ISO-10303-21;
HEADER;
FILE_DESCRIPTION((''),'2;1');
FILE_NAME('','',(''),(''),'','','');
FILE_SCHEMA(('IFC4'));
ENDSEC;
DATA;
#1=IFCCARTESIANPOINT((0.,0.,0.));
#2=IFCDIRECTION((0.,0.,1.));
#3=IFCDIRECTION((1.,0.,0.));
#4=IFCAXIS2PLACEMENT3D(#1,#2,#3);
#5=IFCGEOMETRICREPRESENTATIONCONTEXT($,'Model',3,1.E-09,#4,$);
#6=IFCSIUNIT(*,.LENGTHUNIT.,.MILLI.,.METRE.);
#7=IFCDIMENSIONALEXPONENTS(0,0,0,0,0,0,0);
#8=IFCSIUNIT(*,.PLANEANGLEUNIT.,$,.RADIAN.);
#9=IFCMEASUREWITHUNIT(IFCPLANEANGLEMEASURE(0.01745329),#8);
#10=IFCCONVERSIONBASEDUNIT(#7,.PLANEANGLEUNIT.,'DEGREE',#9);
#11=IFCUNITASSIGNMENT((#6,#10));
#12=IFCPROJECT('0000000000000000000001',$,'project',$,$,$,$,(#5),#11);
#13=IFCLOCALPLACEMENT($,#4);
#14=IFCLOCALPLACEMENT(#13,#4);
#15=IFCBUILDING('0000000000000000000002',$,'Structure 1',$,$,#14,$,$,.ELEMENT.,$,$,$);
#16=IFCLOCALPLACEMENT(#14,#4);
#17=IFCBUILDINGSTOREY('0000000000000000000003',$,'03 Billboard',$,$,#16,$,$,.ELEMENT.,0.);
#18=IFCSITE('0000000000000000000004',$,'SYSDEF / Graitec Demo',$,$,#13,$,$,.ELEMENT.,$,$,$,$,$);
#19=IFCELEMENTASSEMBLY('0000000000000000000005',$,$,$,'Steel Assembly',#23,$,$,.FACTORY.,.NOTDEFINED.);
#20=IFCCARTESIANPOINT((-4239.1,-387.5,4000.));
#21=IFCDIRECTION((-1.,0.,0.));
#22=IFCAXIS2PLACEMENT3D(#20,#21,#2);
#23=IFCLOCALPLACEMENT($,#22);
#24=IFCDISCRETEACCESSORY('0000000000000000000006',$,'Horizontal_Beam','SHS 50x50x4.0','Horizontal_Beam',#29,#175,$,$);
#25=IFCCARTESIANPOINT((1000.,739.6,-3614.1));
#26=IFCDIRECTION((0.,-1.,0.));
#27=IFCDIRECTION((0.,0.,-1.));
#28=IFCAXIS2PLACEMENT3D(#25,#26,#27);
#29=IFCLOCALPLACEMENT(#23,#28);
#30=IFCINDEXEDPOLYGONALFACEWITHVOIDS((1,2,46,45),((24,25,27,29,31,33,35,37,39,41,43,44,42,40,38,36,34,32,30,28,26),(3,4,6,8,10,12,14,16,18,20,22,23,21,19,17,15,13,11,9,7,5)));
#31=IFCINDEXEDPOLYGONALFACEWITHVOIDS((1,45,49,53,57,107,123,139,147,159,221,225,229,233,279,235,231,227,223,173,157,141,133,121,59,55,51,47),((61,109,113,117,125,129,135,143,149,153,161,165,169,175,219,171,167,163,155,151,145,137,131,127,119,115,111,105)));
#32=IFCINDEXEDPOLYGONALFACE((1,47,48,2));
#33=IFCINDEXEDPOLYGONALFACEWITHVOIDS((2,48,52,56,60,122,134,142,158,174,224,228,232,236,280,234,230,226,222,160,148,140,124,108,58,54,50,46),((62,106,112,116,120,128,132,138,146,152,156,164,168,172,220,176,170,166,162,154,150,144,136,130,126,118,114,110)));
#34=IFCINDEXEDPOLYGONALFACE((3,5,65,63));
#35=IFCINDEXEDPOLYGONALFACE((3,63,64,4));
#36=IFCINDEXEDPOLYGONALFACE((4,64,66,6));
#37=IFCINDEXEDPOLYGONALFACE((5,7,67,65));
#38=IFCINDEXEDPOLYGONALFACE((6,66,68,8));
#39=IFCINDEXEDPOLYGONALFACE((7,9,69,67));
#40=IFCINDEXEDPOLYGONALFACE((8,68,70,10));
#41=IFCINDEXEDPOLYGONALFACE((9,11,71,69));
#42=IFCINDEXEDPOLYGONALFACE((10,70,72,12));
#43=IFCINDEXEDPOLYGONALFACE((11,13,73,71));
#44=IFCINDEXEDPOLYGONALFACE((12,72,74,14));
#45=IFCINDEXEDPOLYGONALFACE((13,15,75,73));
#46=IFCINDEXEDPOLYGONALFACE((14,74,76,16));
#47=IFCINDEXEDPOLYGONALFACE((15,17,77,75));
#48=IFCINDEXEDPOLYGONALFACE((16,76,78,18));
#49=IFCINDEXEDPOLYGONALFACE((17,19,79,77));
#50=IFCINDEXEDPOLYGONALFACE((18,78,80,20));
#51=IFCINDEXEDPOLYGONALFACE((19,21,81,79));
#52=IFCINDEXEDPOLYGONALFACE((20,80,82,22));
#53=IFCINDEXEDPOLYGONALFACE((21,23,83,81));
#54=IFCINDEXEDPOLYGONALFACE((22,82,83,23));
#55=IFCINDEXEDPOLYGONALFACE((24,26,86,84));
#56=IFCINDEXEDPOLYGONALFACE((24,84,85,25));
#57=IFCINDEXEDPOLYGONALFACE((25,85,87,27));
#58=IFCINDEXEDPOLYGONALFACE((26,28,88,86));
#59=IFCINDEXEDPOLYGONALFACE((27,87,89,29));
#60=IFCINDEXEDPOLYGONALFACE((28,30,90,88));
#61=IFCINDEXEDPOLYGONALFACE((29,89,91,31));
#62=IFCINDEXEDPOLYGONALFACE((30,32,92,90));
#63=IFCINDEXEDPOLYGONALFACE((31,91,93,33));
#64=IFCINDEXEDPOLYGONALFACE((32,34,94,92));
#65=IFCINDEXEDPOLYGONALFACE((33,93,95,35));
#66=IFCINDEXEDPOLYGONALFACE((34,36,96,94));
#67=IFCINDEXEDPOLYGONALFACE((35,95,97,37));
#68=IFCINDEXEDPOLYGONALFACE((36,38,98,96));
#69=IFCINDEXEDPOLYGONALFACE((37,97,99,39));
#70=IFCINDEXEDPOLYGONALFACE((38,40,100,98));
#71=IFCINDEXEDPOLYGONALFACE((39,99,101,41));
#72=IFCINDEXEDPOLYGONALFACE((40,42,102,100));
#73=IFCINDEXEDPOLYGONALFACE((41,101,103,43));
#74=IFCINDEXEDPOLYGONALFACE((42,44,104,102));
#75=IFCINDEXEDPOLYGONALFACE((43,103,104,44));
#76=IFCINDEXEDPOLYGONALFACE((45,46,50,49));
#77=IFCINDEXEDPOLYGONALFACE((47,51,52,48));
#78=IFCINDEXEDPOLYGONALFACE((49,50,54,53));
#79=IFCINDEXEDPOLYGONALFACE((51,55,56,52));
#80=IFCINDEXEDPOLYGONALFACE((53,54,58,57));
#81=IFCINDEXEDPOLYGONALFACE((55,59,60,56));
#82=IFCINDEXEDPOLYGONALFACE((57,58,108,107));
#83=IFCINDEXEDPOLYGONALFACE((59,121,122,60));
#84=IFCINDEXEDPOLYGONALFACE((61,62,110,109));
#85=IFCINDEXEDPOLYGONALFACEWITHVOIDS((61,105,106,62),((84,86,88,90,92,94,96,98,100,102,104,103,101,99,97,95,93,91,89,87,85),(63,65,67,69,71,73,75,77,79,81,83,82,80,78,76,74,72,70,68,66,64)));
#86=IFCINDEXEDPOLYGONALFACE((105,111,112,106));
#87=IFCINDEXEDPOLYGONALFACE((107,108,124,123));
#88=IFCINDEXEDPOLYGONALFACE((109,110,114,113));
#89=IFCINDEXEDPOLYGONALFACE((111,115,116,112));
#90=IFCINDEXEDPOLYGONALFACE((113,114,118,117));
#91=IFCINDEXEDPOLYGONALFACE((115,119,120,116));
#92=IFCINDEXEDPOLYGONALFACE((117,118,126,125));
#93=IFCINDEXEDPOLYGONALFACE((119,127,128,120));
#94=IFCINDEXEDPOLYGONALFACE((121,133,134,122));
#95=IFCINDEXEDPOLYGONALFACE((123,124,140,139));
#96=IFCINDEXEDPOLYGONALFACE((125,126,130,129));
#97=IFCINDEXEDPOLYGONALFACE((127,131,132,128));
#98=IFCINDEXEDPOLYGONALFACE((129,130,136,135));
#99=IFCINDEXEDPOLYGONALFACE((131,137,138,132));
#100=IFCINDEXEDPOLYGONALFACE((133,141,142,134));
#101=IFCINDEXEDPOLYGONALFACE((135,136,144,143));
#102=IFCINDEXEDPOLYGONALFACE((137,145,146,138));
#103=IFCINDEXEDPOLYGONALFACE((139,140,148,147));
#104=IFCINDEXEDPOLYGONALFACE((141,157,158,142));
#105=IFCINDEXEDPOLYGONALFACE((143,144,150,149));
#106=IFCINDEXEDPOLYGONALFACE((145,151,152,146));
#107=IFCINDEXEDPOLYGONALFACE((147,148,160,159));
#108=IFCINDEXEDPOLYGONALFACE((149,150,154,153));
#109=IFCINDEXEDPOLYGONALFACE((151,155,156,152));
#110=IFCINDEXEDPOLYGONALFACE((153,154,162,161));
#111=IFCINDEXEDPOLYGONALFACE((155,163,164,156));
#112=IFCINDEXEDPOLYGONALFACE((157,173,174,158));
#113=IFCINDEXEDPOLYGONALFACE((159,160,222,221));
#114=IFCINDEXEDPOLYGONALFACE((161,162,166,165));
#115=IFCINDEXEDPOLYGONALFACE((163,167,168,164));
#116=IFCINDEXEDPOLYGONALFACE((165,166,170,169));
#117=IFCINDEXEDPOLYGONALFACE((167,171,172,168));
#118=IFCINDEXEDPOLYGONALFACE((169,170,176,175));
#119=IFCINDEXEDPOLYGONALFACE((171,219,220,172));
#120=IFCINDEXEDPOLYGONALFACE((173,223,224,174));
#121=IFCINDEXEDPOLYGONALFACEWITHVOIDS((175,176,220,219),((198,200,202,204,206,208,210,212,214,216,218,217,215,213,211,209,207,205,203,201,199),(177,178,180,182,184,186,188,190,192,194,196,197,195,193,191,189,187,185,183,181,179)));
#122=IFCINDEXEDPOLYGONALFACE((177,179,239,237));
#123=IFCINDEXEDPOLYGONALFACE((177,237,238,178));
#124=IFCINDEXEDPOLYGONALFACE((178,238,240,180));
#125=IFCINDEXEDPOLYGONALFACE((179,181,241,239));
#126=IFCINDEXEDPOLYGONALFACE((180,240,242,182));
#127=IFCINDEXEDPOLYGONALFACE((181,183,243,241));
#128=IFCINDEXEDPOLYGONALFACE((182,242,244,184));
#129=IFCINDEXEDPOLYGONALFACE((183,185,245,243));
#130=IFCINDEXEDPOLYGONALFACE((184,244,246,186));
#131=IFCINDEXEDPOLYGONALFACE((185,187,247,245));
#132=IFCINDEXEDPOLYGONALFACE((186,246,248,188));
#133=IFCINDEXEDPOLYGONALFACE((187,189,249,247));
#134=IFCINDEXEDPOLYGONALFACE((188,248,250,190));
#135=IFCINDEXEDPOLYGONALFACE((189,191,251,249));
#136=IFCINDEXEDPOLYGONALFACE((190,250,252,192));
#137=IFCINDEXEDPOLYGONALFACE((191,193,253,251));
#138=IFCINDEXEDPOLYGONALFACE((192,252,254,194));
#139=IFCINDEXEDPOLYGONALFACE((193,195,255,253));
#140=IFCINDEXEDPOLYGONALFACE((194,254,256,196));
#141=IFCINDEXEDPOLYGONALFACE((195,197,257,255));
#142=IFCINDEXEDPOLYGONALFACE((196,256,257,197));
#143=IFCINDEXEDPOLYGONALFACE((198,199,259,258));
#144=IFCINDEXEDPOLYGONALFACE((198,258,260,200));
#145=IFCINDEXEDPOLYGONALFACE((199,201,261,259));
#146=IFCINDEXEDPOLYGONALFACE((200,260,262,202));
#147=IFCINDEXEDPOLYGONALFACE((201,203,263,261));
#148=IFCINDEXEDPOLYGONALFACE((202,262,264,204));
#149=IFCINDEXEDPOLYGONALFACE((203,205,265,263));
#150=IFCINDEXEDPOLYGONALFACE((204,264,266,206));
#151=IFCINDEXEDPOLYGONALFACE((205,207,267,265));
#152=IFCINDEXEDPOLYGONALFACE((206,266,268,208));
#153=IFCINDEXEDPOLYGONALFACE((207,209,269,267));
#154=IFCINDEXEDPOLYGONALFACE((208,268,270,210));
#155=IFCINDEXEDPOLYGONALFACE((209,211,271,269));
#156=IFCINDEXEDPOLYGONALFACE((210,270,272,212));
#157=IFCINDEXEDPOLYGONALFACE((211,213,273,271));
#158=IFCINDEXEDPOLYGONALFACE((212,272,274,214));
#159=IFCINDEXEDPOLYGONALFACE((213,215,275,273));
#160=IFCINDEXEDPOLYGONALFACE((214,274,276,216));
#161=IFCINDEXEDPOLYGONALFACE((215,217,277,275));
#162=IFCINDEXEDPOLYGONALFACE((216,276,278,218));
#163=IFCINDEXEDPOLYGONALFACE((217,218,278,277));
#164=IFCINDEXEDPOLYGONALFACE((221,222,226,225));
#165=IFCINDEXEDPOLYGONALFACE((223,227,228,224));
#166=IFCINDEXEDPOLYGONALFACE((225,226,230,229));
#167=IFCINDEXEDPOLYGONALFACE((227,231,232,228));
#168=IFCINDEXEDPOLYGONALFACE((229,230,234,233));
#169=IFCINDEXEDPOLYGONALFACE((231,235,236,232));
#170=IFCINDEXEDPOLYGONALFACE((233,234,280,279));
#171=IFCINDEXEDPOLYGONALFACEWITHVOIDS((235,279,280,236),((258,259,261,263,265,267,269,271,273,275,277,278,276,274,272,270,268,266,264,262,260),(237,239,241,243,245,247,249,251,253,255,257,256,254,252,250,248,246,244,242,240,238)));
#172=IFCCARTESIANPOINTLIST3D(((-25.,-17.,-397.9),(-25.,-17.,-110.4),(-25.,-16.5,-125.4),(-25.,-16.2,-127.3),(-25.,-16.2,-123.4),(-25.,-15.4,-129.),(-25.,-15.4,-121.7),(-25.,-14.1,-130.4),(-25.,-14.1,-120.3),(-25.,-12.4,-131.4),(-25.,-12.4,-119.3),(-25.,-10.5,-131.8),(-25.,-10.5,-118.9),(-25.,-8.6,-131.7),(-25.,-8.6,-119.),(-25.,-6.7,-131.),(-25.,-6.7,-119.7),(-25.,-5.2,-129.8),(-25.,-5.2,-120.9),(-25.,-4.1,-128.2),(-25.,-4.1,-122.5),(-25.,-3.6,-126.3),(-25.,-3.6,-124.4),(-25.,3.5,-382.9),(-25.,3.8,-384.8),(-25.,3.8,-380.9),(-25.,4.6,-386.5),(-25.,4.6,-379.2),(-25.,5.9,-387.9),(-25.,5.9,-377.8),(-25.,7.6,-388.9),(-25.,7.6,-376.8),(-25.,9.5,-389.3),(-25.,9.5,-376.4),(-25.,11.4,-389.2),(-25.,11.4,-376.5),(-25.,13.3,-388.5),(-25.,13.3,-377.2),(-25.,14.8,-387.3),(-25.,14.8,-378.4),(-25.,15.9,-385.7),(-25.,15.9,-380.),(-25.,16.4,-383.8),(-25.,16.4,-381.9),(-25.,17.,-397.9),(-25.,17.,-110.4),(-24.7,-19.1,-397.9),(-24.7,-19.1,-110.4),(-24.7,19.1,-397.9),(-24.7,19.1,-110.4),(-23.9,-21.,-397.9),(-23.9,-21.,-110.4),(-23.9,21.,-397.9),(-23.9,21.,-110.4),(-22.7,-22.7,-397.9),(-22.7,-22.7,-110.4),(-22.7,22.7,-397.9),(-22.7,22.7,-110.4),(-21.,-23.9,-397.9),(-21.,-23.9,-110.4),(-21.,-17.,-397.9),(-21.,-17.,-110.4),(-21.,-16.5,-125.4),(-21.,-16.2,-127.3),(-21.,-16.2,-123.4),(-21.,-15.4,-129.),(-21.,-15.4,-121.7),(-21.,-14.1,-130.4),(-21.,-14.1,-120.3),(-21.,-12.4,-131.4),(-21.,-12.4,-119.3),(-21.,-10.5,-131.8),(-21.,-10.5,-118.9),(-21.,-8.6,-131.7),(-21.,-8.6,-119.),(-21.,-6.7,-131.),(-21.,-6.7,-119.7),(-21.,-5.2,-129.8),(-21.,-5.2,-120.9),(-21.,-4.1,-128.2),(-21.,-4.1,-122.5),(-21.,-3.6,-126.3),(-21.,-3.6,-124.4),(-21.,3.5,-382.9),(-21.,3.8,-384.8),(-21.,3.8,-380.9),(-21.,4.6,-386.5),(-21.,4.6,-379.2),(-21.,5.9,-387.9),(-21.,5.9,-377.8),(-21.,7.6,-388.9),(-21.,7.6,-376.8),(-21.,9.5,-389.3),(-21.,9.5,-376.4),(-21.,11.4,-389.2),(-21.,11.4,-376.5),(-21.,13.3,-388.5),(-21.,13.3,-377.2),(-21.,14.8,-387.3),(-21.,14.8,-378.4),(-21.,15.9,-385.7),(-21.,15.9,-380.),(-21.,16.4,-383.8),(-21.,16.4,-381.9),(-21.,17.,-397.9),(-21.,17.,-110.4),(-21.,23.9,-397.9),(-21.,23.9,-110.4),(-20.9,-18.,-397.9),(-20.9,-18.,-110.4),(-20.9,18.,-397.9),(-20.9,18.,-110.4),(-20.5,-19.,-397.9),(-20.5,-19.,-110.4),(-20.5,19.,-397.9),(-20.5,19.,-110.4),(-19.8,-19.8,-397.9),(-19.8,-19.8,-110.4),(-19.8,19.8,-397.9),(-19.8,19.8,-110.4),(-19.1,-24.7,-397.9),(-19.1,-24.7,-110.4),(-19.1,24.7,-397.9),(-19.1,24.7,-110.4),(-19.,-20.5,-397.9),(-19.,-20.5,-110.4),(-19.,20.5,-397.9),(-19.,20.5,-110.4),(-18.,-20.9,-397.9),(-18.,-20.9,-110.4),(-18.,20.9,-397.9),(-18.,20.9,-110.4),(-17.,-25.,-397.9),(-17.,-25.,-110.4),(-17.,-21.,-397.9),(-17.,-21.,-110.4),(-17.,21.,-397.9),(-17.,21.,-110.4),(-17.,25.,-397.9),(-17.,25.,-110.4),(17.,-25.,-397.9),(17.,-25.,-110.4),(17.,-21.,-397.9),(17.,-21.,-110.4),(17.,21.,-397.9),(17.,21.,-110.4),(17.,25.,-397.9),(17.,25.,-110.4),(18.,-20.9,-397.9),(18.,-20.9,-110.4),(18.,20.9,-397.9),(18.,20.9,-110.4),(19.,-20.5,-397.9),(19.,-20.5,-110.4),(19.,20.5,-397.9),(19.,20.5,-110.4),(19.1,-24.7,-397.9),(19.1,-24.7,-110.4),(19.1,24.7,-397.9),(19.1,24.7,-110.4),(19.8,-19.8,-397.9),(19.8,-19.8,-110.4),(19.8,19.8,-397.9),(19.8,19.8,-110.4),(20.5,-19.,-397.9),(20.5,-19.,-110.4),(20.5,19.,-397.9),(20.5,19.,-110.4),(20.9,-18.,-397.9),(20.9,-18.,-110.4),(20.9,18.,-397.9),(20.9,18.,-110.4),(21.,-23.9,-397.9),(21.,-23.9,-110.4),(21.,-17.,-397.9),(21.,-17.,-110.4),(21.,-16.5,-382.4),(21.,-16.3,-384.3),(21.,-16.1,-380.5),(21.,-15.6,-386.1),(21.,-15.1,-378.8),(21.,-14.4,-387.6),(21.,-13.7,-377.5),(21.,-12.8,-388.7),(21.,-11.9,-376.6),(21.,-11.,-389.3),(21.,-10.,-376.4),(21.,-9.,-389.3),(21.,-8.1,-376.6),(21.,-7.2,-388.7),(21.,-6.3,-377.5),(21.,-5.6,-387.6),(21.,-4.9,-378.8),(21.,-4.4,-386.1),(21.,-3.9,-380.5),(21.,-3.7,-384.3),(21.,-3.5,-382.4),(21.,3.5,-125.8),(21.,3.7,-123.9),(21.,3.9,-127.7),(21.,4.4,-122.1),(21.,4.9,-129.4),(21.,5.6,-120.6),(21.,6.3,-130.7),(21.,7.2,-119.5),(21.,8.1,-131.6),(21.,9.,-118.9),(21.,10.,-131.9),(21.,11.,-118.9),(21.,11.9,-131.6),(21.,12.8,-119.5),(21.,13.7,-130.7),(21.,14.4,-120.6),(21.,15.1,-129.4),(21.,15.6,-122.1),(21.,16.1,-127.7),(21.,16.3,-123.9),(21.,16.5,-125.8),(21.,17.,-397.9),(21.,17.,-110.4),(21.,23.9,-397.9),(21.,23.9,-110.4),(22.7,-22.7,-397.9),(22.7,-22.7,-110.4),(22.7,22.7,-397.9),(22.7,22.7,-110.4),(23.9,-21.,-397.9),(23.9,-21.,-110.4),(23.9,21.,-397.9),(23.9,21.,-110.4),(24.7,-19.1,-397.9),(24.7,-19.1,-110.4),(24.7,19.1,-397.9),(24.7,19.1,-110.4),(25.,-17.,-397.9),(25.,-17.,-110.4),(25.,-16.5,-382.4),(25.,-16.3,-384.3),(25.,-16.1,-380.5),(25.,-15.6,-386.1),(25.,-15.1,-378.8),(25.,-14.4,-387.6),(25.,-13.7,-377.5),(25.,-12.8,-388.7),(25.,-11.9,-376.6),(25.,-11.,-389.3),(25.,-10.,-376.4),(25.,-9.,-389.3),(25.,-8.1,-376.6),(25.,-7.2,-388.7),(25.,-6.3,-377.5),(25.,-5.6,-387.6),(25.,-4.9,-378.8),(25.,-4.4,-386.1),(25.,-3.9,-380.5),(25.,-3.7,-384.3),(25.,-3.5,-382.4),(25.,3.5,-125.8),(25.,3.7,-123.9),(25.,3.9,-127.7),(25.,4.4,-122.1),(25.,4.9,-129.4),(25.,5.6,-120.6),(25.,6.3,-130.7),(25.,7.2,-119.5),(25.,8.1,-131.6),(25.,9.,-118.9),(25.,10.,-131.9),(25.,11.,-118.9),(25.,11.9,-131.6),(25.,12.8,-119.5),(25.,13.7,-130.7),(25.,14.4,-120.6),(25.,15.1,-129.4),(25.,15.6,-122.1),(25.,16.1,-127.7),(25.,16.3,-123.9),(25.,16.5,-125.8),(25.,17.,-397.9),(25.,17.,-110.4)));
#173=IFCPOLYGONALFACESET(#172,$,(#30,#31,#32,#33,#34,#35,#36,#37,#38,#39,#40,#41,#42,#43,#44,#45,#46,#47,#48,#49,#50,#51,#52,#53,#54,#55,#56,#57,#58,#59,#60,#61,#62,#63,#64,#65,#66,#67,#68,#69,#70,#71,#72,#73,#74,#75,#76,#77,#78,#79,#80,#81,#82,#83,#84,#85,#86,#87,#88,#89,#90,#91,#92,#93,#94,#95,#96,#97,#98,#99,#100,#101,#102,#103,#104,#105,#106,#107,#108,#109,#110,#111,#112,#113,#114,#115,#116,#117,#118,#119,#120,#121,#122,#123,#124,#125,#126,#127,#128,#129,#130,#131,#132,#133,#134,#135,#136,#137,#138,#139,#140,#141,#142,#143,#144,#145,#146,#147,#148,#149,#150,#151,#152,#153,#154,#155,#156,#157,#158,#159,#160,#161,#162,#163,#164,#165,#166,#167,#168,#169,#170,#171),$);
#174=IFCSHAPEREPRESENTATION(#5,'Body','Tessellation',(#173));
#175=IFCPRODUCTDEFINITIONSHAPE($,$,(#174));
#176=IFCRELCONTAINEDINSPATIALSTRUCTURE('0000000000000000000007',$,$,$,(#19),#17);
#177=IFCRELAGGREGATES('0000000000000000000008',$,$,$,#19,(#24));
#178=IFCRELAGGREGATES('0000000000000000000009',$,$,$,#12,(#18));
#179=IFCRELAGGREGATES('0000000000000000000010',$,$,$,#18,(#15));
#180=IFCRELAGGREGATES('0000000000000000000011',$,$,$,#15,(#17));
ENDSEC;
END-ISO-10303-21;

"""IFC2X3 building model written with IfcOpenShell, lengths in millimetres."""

from ifc_helpers import new_model, entity, si_unit, converted_unit, frame, frame_2d, origin, origin_with_axes, origin_2d, origin_2d_with_axis, place, context, project, spatial, hollow_rectangle, circle, extrude, clip, halfspace, element, aggregate, save


model = new_model("IFC2X3")

# Units and contexts
model_context = context("Model", 3, precision=1e-09, world=origin_with_axes())
ifc_project = project(units=[si_unit("LENGTHUNIT", "METRE", prefix="MILLI"), converted_unit("PLANEANGLEUNIT", "DEGREE", entity("IfcPlaneAngleMeasure", 0.01745329), si_unit("PLANEANGLEUNIT", "RADIAN"), dimensions=[0, 0, 0, 0, 0, 0, 0])], contexts=[model_context])

# Site, building, storey
site_placement = place(None, origin_with_axes())
site = spatial("IfcSite", under=ifc_project, at=site_placement, Name="SYSDEF / Graitec Demo", CompositionType="ELEMENT")
building_placement = place(site_placement, origin_with_axes())
building = spatial("IfcBuilding", under=site, at=building_placement, Name="Structure 1", CompositionType="ELEMENT")
storey_placement = place(building_placement, origin_with_axes())
storey = spatial("IfcBuildingStorey", under=building, at=storey_placement, Name="03 Billboard", CompositionType="ELEMENT", Elevation=0.0)

# Element assembly, discrete accessory, openings
assembly_1_placement = place(None, frame((-4239.1, -387.5, 4000.0), z_axis=(-1.0, 0.0, 0.0), x_axis=(0.0, 0.0, 1.0)))
assembly_1 = element("IfcElementAssembly", 1, at=assembly_1_placement, inside=storey, ObjectType="Steel Assembly", AssemblyPlace="FACTORY", PredefinedType="NOTDEFINED")
discrete_accessory_1_placement = place(assembly_1_placement, frame((1000.0, 739.6, -3614.1), z_axis=(0.0, -1.0, 0.0), x_axis=(0.0, 0.0, -1.0)))
discrete_accessory_1 = element("IfcDiscreteAccessory", 2, at=discrete_accessory_1_placement, Name="Horizontal_Beam", Description="SHS 50x50x4.0", ObjectType="Horizontal_Beam", context=model_context, shape_type="Clipping", body=[
    clip(clip(extrude(hollow_rectangle(XDim=50.0, YDim=50.0, WallThickness=4.0, InnerFilletRadius=4.0, OuterFilletRadius=8.0, at=origin_2d()), origin(), (0.0, 0.0, -1.0), 483.2), halfspace(frame((625.0, -5000.0, -397.9), z_axis=(0.0, 0.0, 1.0), x_axis=(1.0, 0.0, 0.0)), True)), halfspace(frame((625.0, -5000.0, -110.4), z_axis=(0.0, 0.0, -1.0), x_axis=(-1.0, 0.0, 0.0)), True)),
])
opening_1_placement = place(discrete_accessory_1_placement, frame((20.5, -10.0, -382.9), z_axis=(1.0, 0.0, 0.0), x_axis=(0.0, 0.0, 1.0)))
element("IfcOpeningElement", 3, at=opening_1_placement, cuts=discrete_accessory_1, ObjectType="Opening", context=model_context, shape_type="SweptSolid", body=[
    extrude(circle(Radius=6.5, at=origin_2d_with_axis()), origin(), (0.0, 0.0, 1.0), 5.0),
])
opening_2_placement = place(discrete_accessory_1_placement, frame((20.5, 10.0, -125.4), z_axis=(1.0, 0.0, 0.0), x_axis=(0.0, 0.0, -1.0)))
element("IfcOpeningElement", 4, at=opening_2_placement, cuts=discrete_accessory_1, ObjectType="Opening", context=model_context, shape_type="SweptSolid", body=[
    extrude(circle(Radius=6.5, at=origin_2d_with_axis()), origin(), (0.0, 0.0, 1.0), 5.0),
])
opening_3_placement = place(discrete_accessory_1_placement, frame((-25.5, -10.0, -118.9), z_axis=(-1.0, 0.0, 0.0), x_axis=(0.0, -1.0, 0.0)))
element("IfcOpeningElement", 5, at=opening_3_placement, cuts=discrete_accessory_1, ObjectType="Opening", context=model_context, shape_type="SweptSolid", body=[
    extrude(circle(Radius=6.5, at=frame_2d((0.0, -6.5), x_axis=(1.0, 0.0))), origin(), (0.0, 0.0, -1.0), 5.0),
])
opening_4_placement = place(discrete_accessory_1_placement, frame((-25.5, 10.0, -389.4), z_axis=(-1.0, 0.0, 0.0), x_axis=(0.0, -1.0, 0.0)))
element("IfcOpeningElement", 6, at=opening_4_placement, cuts=discrete_accessory_1, ObjectType="Opening", context=model_context, shape_type="SweptSolid", body=[
    extrude(circle(Radius=6.5, at=frame_2d((0.0, 6.5), x_axis=(1.0, 0.0))), origin(), (0.0, 0.0, -1.0), 5.0),
])
aggregate(assembly_1, [discrete_accessory_1])

save(model, "model.ifc")
